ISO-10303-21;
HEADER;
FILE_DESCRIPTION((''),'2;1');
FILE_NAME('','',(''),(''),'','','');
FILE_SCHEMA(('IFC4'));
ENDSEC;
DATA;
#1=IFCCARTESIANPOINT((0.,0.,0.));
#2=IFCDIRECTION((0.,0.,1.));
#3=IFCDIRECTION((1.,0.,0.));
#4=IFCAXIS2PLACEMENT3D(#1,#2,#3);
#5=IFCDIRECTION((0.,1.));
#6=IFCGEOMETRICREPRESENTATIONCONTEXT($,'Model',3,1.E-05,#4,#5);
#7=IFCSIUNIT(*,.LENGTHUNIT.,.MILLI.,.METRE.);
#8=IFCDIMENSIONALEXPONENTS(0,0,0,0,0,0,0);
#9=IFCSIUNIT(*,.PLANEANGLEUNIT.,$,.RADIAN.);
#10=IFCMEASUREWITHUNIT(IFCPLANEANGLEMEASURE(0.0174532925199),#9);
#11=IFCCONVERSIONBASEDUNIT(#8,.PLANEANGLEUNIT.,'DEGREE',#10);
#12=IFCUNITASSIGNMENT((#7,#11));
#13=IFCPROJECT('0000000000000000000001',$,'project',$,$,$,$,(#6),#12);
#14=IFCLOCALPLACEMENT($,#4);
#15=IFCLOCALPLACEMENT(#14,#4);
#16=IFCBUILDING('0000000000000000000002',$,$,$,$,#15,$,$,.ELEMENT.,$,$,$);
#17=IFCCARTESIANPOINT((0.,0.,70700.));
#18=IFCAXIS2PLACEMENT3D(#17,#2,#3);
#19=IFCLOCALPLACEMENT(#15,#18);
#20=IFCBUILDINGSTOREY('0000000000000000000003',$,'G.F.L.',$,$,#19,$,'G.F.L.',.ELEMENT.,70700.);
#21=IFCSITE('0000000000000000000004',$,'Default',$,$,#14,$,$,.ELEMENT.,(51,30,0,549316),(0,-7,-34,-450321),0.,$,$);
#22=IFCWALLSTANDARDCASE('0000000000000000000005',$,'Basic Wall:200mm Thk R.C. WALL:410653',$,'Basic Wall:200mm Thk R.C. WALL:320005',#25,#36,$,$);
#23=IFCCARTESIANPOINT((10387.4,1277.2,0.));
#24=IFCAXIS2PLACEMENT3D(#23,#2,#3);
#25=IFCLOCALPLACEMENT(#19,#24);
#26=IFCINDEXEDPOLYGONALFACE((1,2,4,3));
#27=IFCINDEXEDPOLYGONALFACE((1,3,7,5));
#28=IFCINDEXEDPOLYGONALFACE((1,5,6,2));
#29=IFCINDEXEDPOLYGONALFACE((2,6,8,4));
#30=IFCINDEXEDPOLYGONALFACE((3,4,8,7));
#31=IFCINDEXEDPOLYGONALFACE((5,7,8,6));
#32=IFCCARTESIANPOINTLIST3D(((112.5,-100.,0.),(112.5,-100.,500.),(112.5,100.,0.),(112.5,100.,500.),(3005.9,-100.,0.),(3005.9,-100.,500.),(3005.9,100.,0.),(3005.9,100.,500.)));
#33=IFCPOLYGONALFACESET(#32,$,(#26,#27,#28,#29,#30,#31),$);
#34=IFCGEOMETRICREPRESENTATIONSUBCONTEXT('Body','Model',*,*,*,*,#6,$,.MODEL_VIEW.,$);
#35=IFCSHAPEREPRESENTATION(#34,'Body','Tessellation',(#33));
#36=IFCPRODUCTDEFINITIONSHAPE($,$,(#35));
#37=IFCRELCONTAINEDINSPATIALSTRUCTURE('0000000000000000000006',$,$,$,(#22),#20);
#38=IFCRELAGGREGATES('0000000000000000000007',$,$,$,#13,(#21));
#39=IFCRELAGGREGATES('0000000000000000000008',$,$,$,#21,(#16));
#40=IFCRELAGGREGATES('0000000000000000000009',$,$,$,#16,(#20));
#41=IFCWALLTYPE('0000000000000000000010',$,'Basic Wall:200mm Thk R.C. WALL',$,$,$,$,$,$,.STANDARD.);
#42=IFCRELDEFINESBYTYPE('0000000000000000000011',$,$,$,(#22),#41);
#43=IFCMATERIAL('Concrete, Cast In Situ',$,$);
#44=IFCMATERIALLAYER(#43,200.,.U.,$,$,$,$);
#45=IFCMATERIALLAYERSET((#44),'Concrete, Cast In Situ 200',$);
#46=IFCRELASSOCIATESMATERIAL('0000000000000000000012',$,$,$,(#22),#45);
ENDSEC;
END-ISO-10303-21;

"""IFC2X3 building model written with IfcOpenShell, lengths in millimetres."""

from ifc_helpers import new_model, entity, si_unit, converted_unit, direction, frame, origin_with_axes, place, context, subcontext, project, spatial, polyline, outline, extrude, material, layer, layer_set, layer_usage, type_object, element, save


model = new_model("IFC2X3")

# Units and contexts
model_context = context("Model", 3, precision=1e-05, world=origin_with_axes(), true_north=direction((0.0, 1.0)))
body_context = subcontext(model_context, "Body", "Model", "MODEL_VIEW")
ifc_project = project(units=[si_unit("LENGTHUNIT", "METRE", prefix="MILLI"), converted_unit("PLANEANGLEUNIT", "DEGREE", entity("IfcPlaneAngleMeasure", 0.0174532925199), si_unit("PLANEANGLEUNIT", "RADIAN"), dimensions=[0, 0, 0, 0, 0, 0, 0])], contexts=[model_context])

# Site, building, storey
site_placement = place(None, origin_with_axes())
site = spatial("IfcSite", under=ifc_project, at=site_placement, Name="Default", CompositionType="ELEMENT", RefLatitude=(51, 30, 0, 549316), RefLongitude=(0, -7, -34, -450321), RefElevation=0.0)
building_placement = place(site_placement, origin_with_axes())
building = spatial("IfcBuilding", under=site, at=building_placement, CompositionType="ELEMENT")
storey_placement = place(building_placement, frame((0.0, 0.0, 70700.0), z_axis=(0.0, 0.0, 1.0), x_axis=(1.0, 0.0, 0.0)))
storey = spatial("IfcBuildingStorey", under=building, at=storey_placement, Name="G.F.L.", LongName="G.F.L.", CompositionType="ELEMENT", Elevation=70700.0)

# Shared definitions
ifc_material_1 = material(Name="Concrete, Cast In Situ")
ifc_layer_1 = layer(ifc_material_1, 200.0, ventilated="UNKNOWN")
ifc_layer_set_1 = layer_set([ifc_layer_1], Name="Concrete, Cast In Situ 200")

# Wall
wall_type_1 = type_object("IfcWallType", Name="Basic Wall:200mm Thk R.C. WALL", PredefinedType="STANDARD")
ifc_layer_usage_1 = layer_usage(ifc_layer_set_1, "AXIS2", "POSITIVE", -100.0)
wall_1_placement = place(storey_placement, frame((10387.4, 1277.2, 0.0), z_axis=(0.0, 0.0, 1.0), x_axis=(1.0, 0.0, 0.0)))
element("IfcWallStandardCase", 1, at=wall_1_placement, inside=storey, type_object=wall_type_1, material=ifc_layer_usage_1, Name="Basic Wall:200mm Thk R.C. WALL:410653", ObjectType="Basic Wall:200mm Thk R.C. WALL:320005", context=body_context, shape_type="SweptSolid", body=[
    extrude(outline(polyline([(112.5, -100.0), (3005.9, -100.0), (3005.9, 100.0), (112.5, 100.0), (112.5, -100.0)])), origin_with_axes(), (0.0, 0.0, 1.0), 500.0),
])

save(model, "model.ifc")
